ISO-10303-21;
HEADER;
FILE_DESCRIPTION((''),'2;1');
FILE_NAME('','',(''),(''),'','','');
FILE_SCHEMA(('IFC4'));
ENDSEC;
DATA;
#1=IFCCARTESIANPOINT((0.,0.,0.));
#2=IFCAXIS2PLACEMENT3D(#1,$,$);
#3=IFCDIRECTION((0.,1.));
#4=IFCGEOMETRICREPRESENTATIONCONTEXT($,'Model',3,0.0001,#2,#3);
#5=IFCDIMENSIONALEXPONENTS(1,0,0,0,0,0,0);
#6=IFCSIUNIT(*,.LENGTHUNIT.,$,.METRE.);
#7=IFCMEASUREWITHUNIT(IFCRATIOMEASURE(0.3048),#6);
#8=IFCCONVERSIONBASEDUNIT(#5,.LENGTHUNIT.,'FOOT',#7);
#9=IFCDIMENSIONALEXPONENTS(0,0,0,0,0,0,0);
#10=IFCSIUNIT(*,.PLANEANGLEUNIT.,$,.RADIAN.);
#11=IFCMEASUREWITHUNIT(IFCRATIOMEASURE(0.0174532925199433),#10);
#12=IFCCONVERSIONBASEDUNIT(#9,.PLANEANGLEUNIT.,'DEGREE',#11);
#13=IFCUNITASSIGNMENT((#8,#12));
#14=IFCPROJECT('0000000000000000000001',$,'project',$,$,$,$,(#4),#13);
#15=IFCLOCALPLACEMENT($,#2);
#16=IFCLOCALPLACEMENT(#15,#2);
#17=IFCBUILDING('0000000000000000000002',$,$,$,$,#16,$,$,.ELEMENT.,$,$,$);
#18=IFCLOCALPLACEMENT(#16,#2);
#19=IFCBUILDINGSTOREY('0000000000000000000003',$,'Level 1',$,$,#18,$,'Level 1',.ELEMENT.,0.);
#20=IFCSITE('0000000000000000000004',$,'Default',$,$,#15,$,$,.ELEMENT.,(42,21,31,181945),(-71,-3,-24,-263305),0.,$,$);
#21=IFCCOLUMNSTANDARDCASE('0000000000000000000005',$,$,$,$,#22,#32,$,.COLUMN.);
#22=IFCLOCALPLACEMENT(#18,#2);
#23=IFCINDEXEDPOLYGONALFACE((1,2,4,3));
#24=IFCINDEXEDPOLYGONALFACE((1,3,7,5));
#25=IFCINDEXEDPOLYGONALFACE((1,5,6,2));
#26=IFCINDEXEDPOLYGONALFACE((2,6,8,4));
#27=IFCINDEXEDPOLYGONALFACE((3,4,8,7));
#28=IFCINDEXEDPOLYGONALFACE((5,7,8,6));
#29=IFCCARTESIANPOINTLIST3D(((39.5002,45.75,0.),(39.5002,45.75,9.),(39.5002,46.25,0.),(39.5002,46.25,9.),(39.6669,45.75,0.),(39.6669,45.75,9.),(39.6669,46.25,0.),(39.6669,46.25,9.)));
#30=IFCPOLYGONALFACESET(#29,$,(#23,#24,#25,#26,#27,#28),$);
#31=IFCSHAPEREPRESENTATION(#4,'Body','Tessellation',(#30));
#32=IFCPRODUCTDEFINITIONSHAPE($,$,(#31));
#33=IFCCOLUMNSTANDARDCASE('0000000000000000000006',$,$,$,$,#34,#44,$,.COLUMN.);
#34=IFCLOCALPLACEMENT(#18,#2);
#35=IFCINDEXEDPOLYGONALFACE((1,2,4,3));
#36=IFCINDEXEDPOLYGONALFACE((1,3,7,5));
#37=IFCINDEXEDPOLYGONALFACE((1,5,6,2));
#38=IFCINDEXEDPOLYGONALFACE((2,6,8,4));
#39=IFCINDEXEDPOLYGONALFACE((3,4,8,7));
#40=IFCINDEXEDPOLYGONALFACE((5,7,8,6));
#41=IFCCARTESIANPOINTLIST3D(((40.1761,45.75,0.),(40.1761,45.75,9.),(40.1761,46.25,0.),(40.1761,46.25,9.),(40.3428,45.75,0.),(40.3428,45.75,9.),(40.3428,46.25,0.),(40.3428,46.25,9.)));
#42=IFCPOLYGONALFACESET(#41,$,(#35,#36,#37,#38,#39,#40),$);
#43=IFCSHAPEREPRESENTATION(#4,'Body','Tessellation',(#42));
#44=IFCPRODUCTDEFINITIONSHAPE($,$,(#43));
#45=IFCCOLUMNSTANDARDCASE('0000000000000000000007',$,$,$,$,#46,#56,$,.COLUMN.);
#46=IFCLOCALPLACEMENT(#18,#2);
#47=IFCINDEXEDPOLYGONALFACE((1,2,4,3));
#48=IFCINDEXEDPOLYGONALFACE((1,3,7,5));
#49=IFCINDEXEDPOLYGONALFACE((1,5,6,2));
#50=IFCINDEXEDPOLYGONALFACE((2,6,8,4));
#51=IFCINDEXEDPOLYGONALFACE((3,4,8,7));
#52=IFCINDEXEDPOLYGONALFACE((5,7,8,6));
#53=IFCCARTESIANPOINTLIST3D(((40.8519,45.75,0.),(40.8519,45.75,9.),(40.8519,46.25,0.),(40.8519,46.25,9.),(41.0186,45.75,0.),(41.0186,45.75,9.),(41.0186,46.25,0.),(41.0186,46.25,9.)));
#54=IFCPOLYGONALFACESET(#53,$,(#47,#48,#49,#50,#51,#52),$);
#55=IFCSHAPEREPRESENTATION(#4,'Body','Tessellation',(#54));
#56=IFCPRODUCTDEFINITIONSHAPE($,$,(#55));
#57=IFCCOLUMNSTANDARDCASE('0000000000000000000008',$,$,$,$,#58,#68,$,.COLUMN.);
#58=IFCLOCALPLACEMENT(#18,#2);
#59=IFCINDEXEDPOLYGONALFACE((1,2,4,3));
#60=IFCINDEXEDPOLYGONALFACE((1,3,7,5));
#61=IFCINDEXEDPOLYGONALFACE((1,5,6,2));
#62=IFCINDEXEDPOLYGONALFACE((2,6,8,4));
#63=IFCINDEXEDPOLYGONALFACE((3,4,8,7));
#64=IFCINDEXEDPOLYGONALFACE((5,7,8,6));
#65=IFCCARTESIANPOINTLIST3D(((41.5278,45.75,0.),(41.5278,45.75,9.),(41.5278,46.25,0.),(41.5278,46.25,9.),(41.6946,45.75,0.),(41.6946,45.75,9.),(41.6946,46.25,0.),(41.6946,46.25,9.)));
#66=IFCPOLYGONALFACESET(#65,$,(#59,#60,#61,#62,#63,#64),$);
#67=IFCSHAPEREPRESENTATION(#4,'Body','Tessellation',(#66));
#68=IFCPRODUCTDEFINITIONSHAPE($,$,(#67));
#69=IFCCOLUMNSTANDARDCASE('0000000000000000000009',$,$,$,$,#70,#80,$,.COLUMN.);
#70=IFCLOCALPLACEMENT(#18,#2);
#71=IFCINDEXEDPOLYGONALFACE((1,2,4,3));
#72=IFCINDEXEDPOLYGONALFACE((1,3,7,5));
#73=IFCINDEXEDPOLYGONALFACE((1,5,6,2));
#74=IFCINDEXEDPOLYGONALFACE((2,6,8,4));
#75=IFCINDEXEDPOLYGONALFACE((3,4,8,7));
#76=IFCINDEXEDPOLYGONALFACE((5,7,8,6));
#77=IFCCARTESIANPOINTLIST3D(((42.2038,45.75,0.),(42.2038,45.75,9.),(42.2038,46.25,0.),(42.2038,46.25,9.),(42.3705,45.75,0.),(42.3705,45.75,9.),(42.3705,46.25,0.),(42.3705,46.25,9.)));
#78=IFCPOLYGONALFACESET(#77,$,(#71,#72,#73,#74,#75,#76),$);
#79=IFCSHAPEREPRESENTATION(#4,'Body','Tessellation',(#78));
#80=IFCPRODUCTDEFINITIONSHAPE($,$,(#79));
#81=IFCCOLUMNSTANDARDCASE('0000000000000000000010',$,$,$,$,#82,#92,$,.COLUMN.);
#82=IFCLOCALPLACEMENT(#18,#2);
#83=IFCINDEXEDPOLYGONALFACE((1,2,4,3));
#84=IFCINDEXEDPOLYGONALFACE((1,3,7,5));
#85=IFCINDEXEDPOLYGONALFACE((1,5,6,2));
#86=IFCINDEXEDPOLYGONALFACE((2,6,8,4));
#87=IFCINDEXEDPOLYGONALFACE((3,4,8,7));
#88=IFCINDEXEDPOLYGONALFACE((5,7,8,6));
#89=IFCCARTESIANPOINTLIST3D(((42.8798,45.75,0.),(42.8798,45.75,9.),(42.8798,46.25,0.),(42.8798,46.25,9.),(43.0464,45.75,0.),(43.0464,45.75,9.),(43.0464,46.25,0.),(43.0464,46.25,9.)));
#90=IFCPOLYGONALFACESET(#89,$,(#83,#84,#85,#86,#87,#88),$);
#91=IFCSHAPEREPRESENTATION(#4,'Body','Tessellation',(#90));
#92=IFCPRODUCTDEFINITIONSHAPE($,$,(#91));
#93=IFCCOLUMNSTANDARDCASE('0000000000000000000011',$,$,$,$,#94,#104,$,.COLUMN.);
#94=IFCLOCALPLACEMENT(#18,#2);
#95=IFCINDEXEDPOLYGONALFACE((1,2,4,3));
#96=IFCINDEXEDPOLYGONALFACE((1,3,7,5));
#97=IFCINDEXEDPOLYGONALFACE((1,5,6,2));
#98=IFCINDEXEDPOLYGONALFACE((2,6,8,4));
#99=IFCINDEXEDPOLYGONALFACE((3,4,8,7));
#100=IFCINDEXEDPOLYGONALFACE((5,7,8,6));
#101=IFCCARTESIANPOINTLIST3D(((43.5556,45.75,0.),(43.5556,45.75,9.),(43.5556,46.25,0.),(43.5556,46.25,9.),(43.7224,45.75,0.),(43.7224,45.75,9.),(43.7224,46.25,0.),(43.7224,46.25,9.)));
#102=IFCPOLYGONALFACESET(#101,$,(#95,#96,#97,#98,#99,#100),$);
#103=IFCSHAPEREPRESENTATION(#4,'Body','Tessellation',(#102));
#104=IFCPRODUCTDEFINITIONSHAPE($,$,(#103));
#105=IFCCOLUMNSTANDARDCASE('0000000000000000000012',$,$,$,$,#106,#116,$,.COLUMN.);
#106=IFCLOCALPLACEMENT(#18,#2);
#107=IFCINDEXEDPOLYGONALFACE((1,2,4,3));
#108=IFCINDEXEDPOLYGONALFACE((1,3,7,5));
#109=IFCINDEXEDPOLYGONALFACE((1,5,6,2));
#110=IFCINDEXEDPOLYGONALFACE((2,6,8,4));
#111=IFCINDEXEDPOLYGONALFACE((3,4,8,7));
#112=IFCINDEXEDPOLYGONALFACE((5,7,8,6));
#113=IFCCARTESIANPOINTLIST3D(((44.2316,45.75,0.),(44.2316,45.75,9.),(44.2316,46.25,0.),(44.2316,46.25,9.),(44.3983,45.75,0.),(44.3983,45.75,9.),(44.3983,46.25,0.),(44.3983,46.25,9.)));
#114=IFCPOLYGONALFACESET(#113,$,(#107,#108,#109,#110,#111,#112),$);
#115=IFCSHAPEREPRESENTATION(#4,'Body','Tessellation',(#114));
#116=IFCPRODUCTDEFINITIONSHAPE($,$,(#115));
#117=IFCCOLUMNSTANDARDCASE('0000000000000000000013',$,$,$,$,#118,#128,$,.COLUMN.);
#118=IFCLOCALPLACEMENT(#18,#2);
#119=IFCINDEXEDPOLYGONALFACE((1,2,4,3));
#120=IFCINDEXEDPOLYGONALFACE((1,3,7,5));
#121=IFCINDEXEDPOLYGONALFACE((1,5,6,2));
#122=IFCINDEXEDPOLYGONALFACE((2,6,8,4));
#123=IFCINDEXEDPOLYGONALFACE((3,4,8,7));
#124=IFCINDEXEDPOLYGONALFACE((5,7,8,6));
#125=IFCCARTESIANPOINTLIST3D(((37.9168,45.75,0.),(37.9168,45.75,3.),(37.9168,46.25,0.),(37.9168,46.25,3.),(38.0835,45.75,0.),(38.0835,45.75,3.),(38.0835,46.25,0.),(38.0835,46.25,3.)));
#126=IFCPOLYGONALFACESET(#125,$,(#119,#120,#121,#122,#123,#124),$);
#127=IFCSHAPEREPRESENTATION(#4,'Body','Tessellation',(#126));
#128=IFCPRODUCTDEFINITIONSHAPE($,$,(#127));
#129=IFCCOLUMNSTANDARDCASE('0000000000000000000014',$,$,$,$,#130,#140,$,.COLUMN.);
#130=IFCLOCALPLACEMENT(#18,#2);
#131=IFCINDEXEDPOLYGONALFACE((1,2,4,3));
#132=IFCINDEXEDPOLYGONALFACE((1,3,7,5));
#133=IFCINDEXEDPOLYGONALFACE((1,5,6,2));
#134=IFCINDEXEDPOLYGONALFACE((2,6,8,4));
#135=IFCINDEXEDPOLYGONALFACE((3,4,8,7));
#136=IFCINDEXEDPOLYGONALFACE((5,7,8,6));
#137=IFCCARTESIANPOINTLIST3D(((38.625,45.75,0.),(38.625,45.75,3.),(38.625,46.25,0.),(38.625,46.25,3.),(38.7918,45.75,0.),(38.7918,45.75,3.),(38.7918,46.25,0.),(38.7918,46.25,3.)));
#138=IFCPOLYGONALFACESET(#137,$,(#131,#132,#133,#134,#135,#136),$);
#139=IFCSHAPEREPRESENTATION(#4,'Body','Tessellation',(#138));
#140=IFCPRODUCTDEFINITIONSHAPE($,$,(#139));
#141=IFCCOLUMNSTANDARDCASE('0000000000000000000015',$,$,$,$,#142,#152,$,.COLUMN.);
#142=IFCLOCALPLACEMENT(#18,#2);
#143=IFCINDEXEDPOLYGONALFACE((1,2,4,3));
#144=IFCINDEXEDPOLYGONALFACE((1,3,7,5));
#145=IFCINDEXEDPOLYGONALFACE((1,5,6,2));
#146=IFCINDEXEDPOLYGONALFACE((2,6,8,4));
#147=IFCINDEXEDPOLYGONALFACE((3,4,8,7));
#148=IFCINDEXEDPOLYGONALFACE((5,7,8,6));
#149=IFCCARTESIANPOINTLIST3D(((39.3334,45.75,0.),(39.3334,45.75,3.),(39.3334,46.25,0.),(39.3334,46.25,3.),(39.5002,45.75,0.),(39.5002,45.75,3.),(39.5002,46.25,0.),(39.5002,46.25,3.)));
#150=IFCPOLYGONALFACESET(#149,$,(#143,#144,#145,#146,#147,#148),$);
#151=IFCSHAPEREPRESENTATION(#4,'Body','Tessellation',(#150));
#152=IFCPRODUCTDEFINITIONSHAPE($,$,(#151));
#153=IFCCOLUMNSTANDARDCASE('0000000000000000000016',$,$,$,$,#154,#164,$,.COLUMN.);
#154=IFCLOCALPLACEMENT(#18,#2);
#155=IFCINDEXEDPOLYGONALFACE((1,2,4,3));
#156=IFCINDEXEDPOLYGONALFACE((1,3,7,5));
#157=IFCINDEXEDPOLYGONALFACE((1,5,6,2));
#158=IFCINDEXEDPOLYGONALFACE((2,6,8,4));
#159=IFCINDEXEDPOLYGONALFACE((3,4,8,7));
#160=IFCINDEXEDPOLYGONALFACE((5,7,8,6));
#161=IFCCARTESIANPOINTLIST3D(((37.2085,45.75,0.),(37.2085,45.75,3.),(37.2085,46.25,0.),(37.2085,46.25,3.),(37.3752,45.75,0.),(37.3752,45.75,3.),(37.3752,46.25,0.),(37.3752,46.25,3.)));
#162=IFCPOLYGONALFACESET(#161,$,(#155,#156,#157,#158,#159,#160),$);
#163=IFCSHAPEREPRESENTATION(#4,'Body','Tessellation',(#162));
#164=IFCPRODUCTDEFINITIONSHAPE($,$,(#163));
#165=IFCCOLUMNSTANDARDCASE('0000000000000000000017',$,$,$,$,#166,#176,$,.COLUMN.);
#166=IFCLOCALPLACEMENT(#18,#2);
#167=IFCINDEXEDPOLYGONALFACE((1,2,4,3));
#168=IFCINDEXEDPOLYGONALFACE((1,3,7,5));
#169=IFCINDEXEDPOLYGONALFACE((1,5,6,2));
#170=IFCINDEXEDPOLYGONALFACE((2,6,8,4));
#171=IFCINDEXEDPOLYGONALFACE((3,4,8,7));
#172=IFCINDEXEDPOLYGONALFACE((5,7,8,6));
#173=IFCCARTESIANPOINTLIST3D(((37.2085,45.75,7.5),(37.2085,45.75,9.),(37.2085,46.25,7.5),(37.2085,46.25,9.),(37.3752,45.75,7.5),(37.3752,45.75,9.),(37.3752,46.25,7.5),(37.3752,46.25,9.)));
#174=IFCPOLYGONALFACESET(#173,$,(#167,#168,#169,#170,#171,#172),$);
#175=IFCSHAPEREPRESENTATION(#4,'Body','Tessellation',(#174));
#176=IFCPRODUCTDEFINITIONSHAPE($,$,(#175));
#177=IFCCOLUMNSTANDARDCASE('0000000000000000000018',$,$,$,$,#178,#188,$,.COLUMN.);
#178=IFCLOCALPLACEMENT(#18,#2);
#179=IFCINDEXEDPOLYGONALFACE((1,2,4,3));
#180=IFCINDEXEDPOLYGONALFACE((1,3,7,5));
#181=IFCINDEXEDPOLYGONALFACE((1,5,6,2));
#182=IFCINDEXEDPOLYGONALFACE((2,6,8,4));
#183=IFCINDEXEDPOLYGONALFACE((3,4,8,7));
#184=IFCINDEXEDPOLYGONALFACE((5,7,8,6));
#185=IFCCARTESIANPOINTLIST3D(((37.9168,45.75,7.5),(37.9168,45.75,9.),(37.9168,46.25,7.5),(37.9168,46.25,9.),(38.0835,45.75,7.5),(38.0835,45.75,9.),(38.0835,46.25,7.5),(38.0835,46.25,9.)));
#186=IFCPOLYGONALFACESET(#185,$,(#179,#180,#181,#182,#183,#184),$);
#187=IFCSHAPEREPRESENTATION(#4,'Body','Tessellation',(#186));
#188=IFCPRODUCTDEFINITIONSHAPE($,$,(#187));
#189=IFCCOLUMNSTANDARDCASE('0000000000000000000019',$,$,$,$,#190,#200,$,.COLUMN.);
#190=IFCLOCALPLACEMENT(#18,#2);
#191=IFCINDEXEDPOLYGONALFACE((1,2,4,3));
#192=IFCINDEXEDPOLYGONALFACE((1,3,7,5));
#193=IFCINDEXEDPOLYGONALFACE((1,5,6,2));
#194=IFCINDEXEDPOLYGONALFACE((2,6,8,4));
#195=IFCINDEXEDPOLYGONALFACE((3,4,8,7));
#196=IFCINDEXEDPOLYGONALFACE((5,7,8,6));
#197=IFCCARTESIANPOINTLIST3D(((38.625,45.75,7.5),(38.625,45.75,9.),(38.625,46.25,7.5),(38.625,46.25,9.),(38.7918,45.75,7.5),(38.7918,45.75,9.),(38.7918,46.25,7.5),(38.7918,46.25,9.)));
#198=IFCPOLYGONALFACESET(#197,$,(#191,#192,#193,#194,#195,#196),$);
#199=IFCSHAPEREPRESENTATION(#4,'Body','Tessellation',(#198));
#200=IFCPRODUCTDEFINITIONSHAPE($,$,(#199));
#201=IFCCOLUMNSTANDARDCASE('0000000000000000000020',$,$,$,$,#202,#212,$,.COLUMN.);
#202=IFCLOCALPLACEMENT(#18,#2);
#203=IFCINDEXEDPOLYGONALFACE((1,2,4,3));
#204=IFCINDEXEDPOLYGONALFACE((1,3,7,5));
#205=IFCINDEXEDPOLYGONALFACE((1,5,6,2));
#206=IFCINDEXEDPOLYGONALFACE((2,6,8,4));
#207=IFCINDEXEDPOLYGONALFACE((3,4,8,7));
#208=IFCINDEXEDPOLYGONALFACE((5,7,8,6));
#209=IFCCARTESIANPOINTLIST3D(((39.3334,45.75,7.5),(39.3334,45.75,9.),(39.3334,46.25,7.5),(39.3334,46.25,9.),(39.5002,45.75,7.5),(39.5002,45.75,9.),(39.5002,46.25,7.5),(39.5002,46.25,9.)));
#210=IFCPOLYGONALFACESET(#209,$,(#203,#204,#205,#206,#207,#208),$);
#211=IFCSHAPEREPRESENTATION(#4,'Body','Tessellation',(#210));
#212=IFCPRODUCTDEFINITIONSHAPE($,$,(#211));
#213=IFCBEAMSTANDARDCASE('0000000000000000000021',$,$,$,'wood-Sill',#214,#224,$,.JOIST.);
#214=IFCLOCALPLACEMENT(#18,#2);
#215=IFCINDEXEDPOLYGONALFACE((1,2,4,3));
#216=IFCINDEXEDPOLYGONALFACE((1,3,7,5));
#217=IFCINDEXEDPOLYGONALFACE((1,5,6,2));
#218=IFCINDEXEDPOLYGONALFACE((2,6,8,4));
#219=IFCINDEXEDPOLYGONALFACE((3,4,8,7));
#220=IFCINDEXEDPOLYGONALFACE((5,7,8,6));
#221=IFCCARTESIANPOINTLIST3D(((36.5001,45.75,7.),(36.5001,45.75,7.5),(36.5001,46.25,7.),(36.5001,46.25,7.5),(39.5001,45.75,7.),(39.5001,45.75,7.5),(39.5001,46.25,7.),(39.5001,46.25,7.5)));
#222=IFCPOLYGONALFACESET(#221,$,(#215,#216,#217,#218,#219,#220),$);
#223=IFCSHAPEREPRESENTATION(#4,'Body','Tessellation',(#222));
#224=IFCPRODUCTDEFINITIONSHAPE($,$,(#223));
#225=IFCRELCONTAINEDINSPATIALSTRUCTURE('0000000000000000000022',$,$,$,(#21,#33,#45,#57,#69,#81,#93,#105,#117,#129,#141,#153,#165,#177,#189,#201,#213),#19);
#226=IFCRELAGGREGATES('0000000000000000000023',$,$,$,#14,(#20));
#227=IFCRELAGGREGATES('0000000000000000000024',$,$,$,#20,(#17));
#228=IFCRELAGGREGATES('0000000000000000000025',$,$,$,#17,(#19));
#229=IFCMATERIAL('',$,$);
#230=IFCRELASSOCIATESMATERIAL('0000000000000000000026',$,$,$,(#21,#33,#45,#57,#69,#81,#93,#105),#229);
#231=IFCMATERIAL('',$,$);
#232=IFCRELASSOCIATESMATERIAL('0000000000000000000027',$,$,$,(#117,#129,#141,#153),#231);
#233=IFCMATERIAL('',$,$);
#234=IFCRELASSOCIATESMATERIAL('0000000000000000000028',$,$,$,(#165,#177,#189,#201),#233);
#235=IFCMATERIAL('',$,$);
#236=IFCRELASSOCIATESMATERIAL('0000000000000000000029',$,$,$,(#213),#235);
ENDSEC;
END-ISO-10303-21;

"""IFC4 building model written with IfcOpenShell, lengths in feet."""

from ifc_helpers import new_model, entity, si_unit, converted_unit, direction, frame, origin, place, context, project, spatial, rectangle, extrude, material, element, save


model = new_model("IFC4")

# Units and contexts
model_context = context("Model", 3, precision=0.0001, world=origin(), true_north=direction((0.0, 1.0)))
ifc_project = project(units=[converted_unit("LENGTHUNIT", "FOOT", entity("IfcRatioMeasure", 0.3048), si_unit("LENGTHUNIT", "METRE"), dimensions=[1, 0, 0, 0, 0, 0, 0]), converted_unit("PLANEANGLEUNIT", "DEGREE", entity("IfcRatioMeasure", 0.0174532925199433), si_unit("PLANEANGLEUNIT", "RADIAN"), dimensions=[0, 0, 0, 0, 0, 0, 0])], contexts=[model_context])

# Site, building, storey
site_placement = place(None, origin())
site = spatial("IfcSite", under=ifc_project, at=site_placement, Name="Default", CompositionType="ELEMENT", RefLatitude=(42, 21, 31, 181945), RefLongitude=(-71, -3, -24, -263305), RefElevation=0.0)
building_placement = place(site_placement, origin())
building = spatial("IfcBuilding", under=site, at=building_placement, CompositionType="ELEMENT")
storey_placement = place(building_placement, origin())
storey = spatial("IfcBuildingStorey", under=building, at=storey_placement, Name="Level 1", LongName="Level 1", CompositionType="ELEMENT", Elevation=0.0)

# Columns
ifc_material_1 = material(Name="")
placement_1 = place(storey_placement, frame((-0.25, 46.0, 0.0)))
for number, where, z_axis, x_axis in (
    (1, (39.8335, 0.0, 0.0), (0.0, 0.0, 1.0), (1.0, 0.0, 0.0)),
    (2, (40.5094, 0.0, 0.0), (0.0, 0.0, 1.0), (1.0, 0.0, 0.0)),
    (3, (41.1853, 0.0, 0.0), (0.0, 0.0, 1.0), (1.0, 0.0, 0.0)),
    (4, (41.8612, 0.0, 0.0), (0.0, 0.0, 1.0), (1.0, 0.0, 0.0)),
    (5, (42.5371, 0.0, 0.0), (0.0, 0.0, 1.0), (1.0, 0.0, 0.0)),
    (6, (43.2131, 0.0, 0.0), (0.0, 0.0, 1.0), (1.0, 0.0, 0.0)),
    (7, (43.889, 0.0, 0.0), (0.0, 0.0, 1.0), (1.0, 0.0, 0.0)),
    (8, (44.5649, 0.0, 0.0), (0.0, 0.0, 1.0), (1.0, 0.0, 0.0)),
):
    element("IfcColumnStandardCase", number, at=place(placement_1, frame(where, z_axis=z_axis, x_axis=x_axis)), inside=storey, material=ifc_material_1, PredefinedType="COLUMN", context=model_context, shape_type="SweptSolid", body=[
        extrude(rectangle(XDim=0.1667, YDim=0.5), origin(), (0.0, 0.0, 1.0), 9.0),
    ])
ifc_material_2 = material(Name="")
for number, where, z_axis, x_axis in (
    (9, (38.2501, 0.0, 0.0), (0.0, 0.0, 1.0), (1.0, 0.0, 0.0)),
    (10, (38.9584, 0.0, 0.0), (0.0, 0.0, 1.0), (1.0, 0.0, 0.0)),
    (11, (39.6668, 0.0, 0.0), (0.0, 0.0, 1.0), (1.0, 0.0, 0.0)),
    (12, (37.5418, 0.0, 0.0), (0.0, 0.0, 1.0), (1.0, 0.0, 0.0)),
):
    element("IfcColumnStandardCase", number, at=place(placement_1, frame(where, z_axis=z_axis, x_axis=x_axis)), inside=storey, material=ifc_material_2, PredefinedType="COLUMN", context=model_context, shape_type="SweptSolid", body=[
        extrude(rectangle(XDim=0.1667, YDim=0.5), origin(), (0.0, 0.0, 1.0), 3.0),
    ])
ifc_material_3 = material(Name="")
for number, where, z_axis, x_axis in (
    (13, (37.5418, 0.0, 7.5), (0.0, 0.0, 1.0), (1.0, 0.0, 0.0)),
    (14, (38.2501, 0.0, 7.5), (0.0, 0.0, 1.0), (1.0, 0.0, 0.0)),
    (15, (38.9584, 0.0, 7.5), (0.0, 0.0, 1.0), (1.0, 0.0, 0.0)),
    (16, (39.6668, 0.0, 7.5), (0.0, 0.0, 1.0), (1.0, 0.0, 0.0)),
):
    element("IfcColumnStandardCase", number, at=place(placement_1, frame(where, z_axis=z_axis, x_axis=x_axis)), inside=storey, material=ifc_material_3, PredefinedType="COLUMN", context=model_context, shape_type="SweptSolid", body=[
        extrude(rectangle(XDim=0.1667, YDim=0.5), origin(), (0.0, 0.0, 1.0), 1.5),
    ])

# Beam
ifc_material_4 = material(Name="")
for number, where, z_axis, x_axis in (
    (17, (38.2501, 0.0, 7.0), (0.0, 0.0, 1.0), (-1.0, 0.0, 0.0)),
):
    element("IfcBeamStandardCase", number, at=place(placement_1, frame(where, z_axis=z_axis, x_axis=x_axis)), inside=storey, material=ifc_material_4, ObjectType="wood-Sill", PredefinedType="JOIST", context=model_context, shape_type="SweptSolid", body=[
        extrude(rectangle(XDim=3.0, YDim=0.5), origin(), (0.0, 0.0, 1.0), 0.5),
    ])

save(model, "model.ifc")
